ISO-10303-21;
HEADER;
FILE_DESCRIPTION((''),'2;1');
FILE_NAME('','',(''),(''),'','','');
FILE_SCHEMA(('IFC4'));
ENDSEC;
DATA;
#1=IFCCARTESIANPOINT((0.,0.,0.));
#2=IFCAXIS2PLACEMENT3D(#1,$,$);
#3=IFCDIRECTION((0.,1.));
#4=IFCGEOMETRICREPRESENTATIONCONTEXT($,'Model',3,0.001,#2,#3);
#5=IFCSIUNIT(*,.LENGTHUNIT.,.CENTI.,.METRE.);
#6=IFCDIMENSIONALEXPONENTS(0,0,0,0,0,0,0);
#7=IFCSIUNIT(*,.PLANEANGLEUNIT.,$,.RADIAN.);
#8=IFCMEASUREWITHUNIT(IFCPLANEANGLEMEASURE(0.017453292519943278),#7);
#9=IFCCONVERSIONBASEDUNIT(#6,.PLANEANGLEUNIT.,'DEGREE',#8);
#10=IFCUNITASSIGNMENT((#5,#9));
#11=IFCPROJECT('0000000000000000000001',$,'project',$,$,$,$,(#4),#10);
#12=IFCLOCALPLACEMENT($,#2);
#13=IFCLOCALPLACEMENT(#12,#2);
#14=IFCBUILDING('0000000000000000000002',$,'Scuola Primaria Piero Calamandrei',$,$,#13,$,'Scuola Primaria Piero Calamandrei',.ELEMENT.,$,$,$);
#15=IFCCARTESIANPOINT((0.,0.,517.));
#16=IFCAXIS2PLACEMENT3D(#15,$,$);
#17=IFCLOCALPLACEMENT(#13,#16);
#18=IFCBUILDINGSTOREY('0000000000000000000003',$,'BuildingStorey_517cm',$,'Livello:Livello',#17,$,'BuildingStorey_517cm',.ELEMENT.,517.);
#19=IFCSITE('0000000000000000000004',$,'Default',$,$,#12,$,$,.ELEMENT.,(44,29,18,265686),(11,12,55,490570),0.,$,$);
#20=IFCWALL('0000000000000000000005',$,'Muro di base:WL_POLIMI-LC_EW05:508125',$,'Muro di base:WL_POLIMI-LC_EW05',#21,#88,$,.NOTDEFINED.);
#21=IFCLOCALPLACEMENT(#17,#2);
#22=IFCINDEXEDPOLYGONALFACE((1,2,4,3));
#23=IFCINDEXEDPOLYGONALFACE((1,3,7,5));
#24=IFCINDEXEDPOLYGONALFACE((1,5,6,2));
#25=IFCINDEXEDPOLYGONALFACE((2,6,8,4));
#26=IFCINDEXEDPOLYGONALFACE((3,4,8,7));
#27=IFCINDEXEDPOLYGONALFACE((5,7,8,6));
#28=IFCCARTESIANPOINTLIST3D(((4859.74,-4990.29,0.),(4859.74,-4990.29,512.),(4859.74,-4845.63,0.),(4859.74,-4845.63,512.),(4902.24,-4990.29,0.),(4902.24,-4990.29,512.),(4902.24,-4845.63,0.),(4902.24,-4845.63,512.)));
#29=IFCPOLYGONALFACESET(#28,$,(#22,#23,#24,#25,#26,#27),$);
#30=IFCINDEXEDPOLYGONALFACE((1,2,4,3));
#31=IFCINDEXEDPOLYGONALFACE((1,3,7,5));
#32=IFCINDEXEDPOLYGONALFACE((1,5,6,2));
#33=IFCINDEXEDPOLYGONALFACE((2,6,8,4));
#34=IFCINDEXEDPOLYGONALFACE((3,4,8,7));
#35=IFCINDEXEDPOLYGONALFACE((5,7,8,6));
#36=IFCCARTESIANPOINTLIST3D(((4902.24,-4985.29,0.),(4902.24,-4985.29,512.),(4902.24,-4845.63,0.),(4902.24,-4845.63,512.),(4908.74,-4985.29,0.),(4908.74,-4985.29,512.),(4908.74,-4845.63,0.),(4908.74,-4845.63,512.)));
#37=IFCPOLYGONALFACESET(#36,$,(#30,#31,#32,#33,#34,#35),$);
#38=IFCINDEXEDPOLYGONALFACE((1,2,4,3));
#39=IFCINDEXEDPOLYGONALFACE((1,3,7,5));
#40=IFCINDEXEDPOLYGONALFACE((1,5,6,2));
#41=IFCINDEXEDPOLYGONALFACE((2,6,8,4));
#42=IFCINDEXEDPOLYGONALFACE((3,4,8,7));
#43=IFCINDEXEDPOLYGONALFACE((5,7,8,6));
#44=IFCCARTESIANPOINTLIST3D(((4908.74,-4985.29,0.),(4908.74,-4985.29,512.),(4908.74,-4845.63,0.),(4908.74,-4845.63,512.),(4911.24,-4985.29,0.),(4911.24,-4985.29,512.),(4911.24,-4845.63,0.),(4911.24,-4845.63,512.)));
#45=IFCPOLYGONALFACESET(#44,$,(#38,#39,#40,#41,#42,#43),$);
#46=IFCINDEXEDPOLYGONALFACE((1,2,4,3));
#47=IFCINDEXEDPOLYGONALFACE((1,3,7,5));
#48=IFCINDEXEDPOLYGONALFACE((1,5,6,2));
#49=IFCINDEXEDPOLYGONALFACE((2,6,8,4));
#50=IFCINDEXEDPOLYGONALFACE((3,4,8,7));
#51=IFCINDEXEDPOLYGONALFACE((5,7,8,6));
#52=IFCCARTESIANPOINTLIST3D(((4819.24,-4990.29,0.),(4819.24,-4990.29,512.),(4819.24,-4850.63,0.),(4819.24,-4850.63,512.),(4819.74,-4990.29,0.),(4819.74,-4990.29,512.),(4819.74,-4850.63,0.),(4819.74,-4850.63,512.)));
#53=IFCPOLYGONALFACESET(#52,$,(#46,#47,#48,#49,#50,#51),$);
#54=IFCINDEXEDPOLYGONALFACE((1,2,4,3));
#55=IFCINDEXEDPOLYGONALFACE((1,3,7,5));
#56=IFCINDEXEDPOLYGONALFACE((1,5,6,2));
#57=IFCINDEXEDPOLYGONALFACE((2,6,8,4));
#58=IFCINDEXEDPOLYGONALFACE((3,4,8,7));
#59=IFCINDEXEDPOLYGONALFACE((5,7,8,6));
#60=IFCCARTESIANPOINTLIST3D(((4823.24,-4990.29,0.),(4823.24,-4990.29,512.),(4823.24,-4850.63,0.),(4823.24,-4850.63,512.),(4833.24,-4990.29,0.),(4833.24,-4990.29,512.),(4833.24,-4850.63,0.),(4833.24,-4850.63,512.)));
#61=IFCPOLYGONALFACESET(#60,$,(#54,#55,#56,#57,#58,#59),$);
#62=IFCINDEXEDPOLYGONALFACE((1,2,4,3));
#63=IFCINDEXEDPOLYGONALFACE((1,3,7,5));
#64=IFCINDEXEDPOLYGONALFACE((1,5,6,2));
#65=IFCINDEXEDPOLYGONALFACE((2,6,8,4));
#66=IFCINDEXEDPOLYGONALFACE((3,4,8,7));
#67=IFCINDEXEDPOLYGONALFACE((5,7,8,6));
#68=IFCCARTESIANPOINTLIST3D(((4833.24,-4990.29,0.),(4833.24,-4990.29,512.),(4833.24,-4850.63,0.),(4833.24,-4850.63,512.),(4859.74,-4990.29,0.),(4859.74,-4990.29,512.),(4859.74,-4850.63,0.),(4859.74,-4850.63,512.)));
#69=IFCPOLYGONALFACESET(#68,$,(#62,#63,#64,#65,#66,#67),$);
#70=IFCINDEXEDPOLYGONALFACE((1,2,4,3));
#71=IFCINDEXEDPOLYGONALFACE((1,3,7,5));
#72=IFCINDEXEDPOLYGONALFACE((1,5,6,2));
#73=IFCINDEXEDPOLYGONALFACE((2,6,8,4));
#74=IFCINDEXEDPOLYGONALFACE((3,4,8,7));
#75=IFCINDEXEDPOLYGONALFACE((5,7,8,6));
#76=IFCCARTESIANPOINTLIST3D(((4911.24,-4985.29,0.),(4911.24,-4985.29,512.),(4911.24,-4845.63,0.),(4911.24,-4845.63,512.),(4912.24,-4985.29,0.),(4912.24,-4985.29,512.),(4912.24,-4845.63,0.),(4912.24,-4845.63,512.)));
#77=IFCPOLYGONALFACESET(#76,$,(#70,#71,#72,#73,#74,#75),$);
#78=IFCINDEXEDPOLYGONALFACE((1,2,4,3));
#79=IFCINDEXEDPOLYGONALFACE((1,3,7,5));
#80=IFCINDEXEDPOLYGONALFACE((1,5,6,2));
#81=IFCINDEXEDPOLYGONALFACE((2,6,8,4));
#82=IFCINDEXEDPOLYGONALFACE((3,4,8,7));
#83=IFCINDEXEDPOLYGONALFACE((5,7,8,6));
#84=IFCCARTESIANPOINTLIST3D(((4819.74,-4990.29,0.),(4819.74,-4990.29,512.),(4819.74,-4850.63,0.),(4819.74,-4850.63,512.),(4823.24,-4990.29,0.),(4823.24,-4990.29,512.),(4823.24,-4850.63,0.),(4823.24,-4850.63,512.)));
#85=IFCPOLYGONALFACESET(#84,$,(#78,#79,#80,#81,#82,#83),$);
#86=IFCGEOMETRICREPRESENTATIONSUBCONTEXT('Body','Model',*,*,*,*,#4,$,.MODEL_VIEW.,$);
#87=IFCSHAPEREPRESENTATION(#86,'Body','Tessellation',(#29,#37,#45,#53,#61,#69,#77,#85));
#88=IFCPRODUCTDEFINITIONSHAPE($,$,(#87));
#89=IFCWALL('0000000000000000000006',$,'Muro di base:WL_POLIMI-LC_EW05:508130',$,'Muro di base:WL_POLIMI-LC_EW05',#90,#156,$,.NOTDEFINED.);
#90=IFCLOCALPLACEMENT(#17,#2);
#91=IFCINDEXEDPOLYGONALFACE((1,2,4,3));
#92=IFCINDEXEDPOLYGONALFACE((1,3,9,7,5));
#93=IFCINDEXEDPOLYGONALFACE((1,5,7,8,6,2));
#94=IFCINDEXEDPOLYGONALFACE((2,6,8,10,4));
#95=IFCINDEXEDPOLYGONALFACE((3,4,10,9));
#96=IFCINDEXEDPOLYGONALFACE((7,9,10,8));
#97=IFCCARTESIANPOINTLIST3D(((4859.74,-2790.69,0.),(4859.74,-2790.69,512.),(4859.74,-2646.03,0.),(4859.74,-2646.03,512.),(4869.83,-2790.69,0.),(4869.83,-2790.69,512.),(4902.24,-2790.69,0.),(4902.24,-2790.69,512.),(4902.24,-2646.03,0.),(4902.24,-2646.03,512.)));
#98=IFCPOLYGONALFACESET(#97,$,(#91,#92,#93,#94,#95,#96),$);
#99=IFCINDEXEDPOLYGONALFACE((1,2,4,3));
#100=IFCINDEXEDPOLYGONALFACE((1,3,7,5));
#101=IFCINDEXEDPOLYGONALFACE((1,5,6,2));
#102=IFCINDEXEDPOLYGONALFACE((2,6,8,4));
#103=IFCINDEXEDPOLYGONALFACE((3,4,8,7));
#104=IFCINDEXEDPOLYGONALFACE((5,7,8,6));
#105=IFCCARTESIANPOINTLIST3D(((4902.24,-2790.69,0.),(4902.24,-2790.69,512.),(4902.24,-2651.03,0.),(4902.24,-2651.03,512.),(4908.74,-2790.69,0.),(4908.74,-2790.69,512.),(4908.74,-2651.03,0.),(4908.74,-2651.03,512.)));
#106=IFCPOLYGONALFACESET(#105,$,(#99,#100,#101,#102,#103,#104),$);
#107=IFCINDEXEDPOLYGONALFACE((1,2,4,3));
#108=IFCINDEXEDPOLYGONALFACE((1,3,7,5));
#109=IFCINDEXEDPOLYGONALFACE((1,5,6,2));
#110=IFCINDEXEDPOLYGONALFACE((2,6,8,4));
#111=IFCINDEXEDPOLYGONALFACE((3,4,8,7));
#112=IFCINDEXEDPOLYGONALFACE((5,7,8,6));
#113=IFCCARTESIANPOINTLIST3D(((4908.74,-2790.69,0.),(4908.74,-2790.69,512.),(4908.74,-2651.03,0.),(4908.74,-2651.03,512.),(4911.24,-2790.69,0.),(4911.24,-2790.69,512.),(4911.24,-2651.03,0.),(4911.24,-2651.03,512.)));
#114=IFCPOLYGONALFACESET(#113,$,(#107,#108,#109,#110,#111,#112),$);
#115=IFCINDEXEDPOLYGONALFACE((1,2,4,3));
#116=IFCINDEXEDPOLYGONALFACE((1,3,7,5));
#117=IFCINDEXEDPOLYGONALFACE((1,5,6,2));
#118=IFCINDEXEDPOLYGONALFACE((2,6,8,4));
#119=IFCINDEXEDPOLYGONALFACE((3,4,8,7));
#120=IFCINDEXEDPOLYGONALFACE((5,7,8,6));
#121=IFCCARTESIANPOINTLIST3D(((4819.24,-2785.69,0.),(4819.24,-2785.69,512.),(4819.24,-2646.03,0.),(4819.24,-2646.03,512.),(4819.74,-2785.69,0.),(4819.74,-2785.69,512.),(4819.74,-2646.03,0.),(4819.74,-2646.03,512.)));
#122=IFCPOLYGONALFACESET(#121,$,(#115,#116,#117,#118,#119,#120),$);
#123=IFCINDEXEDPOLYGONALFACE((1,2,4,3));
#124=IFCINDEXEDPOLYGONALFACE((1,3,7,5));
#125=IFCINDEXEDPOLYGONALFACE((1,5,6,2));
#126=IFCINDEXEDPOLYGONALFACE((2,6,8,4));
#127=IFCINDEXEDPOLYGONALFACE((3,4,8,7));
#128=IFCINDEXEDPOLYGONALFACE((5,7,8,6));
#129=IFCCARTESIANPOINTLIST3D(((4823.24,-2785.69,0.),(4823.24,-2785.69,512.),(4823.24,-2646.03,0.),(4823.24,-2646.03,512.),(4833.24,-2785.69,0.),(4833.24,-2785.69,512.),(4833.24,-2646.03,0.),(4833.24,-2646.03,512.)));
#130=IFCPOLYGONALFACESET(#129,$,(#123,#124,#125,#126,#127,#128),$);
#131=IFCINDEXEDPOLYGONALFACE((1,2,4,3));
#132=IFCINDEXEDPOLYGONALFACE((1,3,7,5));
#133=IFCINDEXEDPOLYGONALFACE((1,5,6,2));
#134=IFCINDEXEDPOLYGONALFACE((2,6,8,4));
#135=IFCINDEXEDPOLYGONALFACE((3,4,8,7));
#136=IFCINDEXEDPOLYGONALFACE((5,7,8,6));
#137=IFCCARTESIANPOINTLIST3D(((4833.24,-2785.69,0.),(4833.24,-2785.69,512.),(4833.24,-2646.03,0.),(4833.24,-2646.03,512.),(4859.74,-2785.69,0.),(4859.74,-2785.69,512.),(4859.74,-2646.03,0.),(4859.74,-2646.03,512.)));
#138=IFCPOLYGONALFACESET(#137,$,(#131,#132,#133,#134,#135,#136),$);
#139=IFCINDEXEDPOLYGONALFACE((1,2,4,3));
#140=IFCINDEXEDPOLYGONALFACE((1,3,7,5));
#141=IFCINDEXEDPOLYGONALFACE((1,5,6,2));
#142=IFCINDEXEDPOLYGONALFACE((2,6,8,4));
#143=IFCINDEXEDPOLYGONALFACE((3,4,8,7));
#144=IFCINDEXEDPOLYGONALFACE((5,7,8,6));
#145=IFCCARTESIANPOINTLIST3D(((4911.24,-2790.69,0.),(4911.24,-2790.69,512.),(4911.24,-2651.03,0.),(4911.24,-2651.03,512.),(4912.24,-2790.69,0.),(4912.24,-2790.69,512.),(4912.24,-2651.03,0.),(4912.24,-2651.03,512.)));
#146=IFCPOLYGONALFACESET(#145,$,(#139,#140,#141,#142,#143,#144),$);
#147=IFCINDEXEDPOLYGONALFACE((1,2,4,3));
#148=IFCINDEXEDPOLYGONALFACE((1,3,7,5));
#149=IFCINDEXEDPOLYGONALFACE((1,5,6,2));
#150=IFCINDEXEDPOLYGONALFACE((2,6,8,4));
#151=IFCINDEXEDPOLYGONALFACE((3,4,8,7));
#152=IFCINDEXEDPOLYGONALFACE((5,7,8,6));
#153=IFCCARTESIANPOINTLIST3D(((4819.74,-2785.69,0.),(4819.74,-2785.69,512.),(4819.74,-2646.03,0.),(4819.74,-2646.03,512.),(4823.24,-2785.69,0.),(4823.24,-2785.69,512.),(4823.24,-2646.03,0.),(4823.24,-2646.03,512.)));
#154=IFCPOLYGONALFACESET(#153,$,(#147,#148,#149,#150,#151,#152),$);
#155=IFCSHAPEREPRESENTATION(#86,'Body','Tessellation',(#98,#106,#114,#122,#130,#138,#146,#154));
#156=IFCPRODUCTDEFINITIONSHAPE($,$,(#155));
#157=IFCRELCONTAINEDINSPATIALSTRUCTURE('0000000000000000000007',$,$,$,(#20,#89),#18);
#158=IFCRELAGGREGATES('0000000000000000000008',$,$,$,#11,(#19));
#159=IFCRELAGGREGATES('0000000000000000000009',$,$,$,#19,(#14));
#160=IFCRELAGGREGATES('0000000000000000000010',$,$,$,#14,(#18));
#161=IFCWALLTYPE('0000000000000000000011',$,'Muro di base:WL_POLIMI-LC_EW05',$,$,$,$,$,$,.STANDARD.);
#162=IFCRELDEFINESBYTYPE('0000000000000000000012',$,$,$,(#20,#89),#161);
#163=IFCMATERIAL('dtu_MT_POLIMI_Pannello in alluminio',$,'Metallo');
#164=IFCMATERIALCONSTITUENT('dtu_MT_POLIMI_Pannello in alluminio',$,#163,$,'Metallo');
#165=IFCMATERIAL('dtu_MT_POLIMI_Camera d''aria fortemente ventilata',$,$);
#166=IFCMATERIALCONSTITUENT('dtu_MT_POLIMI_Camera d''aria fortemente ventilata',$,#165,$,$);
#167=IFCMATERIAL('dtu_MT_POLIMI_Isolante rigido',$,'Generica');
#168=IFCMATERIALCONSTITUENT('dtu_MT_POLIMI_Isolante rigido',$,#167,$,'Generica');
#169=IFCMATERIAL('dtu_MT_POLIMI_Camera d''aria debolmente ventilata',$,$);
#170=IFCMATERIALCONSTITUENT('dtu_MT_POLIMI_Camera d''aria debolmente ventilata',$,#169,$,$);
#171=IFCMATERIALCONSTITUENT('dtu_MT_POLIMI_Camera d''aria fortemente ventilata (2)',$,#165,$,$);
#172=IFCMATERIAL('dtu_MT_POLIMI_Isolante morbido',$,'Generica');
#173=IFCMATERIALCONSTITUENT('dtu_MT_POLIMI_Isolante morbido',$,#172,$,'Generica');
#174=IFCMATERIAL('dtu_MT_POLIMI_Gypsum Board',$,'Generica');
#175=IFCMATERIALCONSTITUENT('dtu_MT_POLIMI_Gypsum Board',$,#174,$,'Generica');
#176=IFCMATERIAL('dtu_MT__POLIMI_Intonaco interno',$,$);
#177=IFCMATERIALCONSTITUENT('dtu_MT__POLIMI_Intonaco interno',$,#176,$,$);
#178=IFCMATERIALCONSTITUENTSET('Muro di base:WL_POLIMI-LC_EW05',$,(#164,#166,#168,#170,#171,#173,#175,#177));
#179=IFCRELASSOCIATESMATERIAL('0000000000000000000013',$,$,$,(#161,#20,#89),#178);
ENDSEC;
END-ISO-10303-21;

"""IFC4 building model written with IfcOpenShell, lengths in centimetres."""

from ifc_helpers import new_model, entity, si_unit, converted_unit, direction, frame, origin, place, context, subcontext, project, spatial, indexed_curve, outline, extrude, material, constituent, constituent_set, type_object, element, save


model = new_model("IFC4")

# Units and contexts
model_context = context("Model", 3, precision=0.001, world=origin(), true_north=direction((0.0, 1.0)))
body_context = subcontext(model_context, "Body", "Model", "MODEL_VIEW")
ifc_project = project(units=[si_unit("LENGTHUNIT", "METRE", prefix="CENTI"), converted_unit("PLANEANGLEUNIT", "DEGREE", entity("IfcPlaneAngleMeasure", 0.017453292519943278), si_unit("PLANEANGLEUNIT", "RADIAN"), dimensions=[0, 0, 0, 0, 0, 0, 0])], contexts=[model_context])

# Site, building, storey
site_placement = place(None, origin())
site = spatial("IfcSite", under=ifc_project, at=site_placement, Name="Default", CompositionType="ELEMENT", RefLatitude=(44, 29, 18, 265686), RefLongitude=(11, 12, 55, 490570), RefElevation=0.0)
building_placement = place(site_placement, origin())
building = spatial("IfcBuilding", under=site, at=building_placement, Name="Scuola Primaria Piero Calamandrei", LongName="Scuola Primaria Piero Calamandrei", CompositionType="ELEMENT")
storey_placement = place(building_placement, frame((0.0, 0.0, 517.0)))
storey = spatial("IfcBuildingStorey", under=building, at=storey_placement, Name="BuildingStorey_517cm", ObjectType="Livello:Livello", LongName="BuildingStorey_517cm", CompositionType="ELEMENT", Elevation=517.0)

# Shared definitions
ifc_material_1 = material(Name="dtu_MT_POLIMI_Pannello in alluminio", Category="Metallo")
ifc_constituent_1 = constituent(ifc_material_1, Name="dtu_MT_POLIMI_Pannello in alluminio", Category="Metallo")
ifc_material_2 = material(Name="dtu_MT_POLIMI_Camera d'aria fortemente ventilata")
ifc_constituent_2 = constituent(ifc_material_2, Name="dtu_MT_POLIMI_Camera d'aria fortemente ventilata")
ifc_material_3 = material(Name="dtu_MT_POLIMI_Isolante rigido", Category="Generica")
ifc_constituent_3 = constituent(ifc_material_3, Name="dtu_MT_POLIMI_Isolante rigido", Category="Generica")
ifc_material_4 = material(Name="dtu_MT_POLIMI_Camera d'aria debolmente ventilata")
ifc_constituent_4 = constituent(ifc_material_4, Name="dtu_MT_POLIMI_Camera d'aria debolmente ventilata")
ifc_constituent_5 = constituent(ifc_material_2, Name="dtu_MT_POLIMI_Camera d'aria fortemente ventilata (2)")
ifc_material_5 = material(Name="dtu_MT_POLIMI_Isolante morbido", Category="Generica")
ifc_constituent_6 = constituent(ifc_material_5, Name="dtu_MT_POLIMI_Isolante morbido", Category="Generica")
ifc_material_6 = material(Name="dtu_MT_POLIMI_Gypsum Board", Category="Generica")
ifc_constituent_7 = constituent(ifc_material_6, Name="dtu_MT_POLIMI_Gypsum Board", Category="Generica")
ifc_material_7 = material(Name="dtu_MT__POLIMI_Intonaco interno")
ifc_constituent_8 = constituent(ifc_material_7, Name="dtu_MT__POLIMI_Intonaco interno")
ifc_constituent_set_1 = constituent_set(constituents=[ifc_constituent_1, ifc_constituent_2, ifc_constituent_3, ifc_constituent_4, ifc_constituent_5, ifc_constituent_6, ifc_constituent_7, ifc_constituent_8], Name="Muro di base:WL_POLIMI-LC_EW05")
wall_type_1 = type_object("IfcWallType", Name="Muro di base:WL_POLIMI-LC_EW05", PredefinedType="STANDARD", material=ifc_constituent_set_1)

# Walls
wall_1_placement = place(storey_placement, frame((4865.74, -4990.29, 0.0), z_axis=(0.0, 0.0, 1.0), x_axis=(0.0, 1.0, 0.0)))
element("IfcWall", 1, at=wall_1_placement, inside=storey, type_object=wall_type_1, material=ifc_constituent_set_1, Name="Muro di base:WL_POLIMI-LC_EW05:508125", ObjectType="Muro di base:WL_POLIMI-LC_EW05", PredefinedType="NOTDEFINED", context=body_context, shape_type="SweptSolid", body=[
    extrude(outline(indexed_curve([(-72.33, -21.25), (72.33, -21.25), (72.33, 21.25), (-72.33, 21.25), (-72.33, -21.25)], self_intersect=False)), frame((72.33, -15.25, 0.0)), (0.0, 0.0, 1.0), 512.0),
    extrude(outline(indexed_curve([(-69.83, -3.25), (69.83, -3.25), (69.83, 3.25), (-69.83, 3.25), (-69.83, -3.25)], self_intersect=False)), frame((74.83, -39.75, 0.0)), (0.0, 0.0, 1.0), 512.0),
    extrude(outline(indexed_curve([(-69.83, -1.25), (69.83, -1.25), (69.83, 1.25), (-69.83, 1.25), (-69.83, -1.25)], self_intersect=False)), frame((74.83, -44.25, 0.0)), (0.0, 0.0, 1.0), 512.0),
    extrude(outline(indexed_curve([(-69.83, -0.25), (69.83, -0.25), (69.83, 0.25), (-69.83, 0.25), (-69.83, -0.25)], self_intersect=False)), frame((69.83, 46.25, 0.0), z_axis=(0.0, 0.0, 1.0), x_axis=(-1.0, 0.0, 0.0)), (0.0, 0.0, 1.0), 512.0),
    extrude(outline(indexed_curve([(-69.83, -5.0), (69.83, -5.0), (69.83, 5.0), (-69.83, 5.0), (-69.83, -5.0)], self_intersect=False)), frame((69.83, 37.5, 0.0)), (0.0, 0.0, 1.0), 512.0),
    extrude(outline(indexed_curve([(-69.83, -13.25), (69.83, -13.25), (69.83, 13.25), (-69.83, 13.25), (-69.83, -13.25)], self_intersect=False)), frame((69.83, 19.25, 0.0)), (0.0, 0.0, 1.0), 512.0),
    extrude(outline(indexed_curve([(-69.83, -0.5), (69.83, -0.5), (69.83, 0.5), (-69.83, 0.5), (-69.83, -0.5)], self_intersect=False)), frame((74.83, -46.0, 0.0)), (0.0, 0.0, 1.0), 512.0),
    extrude(outline(indexed_curve([(-69.83, -1.75), (69.83, -1.75), (69.83, 1.75), (-69.83, 1.75), (-69.83, -1.75)], self_intersect=False)), frame((69.83, 44.25, 0.0)), (0.0, 0.0, 1.0), 512.0),
])
wall_2_placement = place(storey_placement, frame((4865.74, -2790.69, 0.0), z_axis=(0.0, 0.0, 1.0), x_axis=(0.0, 1.0, 0.0)))
element("IfcWall", 2, at=wall_2_placement, inside=storey, type_object=wall_type_1, material=ifc_constituent_set_1, Name="Muro di base:WL_POLIMI-LC_EW05:508130", ObjectType="Muro di base:WL_POLIMI-LC_EW05", PredefinedType="NOTDEFINED", context=body_context, shape_type="SweptSolid", body=[
    extrude(outline(indexed_curve([(-57.86, -23.48), (86.79, -23.48), (86.79, 19.02), (-57.86, 19.02), (-57.86, 8.93), (-57.86, -23.48)], self_intersect=False)), frame((57.86, -13.02, 0.0)), (0.0, 0.0, 1.0), 512.0),
    extrude(outline(indexed_curve([(-69.83, -3.25), (69.83, -3.25), (69.83, 3.25), (-69.83, 3.25), (-69.83, -3.25)], self_intersect=False)), frame((69.83, -39.75, 0.0)), (0.0, 0.0, 1.0), 512.0),
    extrude(outline(indexed_curve([(-69.83, -1.25), (69.83, -1.25), (69.83, 1.25), (-69.83, 1.25), (-69.83, -1.25)], self_intersect=False)), frame((69.83, -44.25, 0.0)), (0.0, 0.0, 1.0), 512.0),
    extrude(outline(indexed_curve([(-0.25, -69.83), (0.25, -69.83), (0.25, 69.83), (-0.25, 69.83), (-0.25, -69.83)], self_intersect=False)), frame((74.83, 46.25, 0.0), z_axis=(0.0, 0.0, 1.0), x_axis=(0.0, -1.0, 0.0)), (0.0, 0.0, 1.0), 512.0),
    extrude(outline(indexed_curve([(-69.83, -5.0), (69.83, -5.0), (69.83, 5.0), (-69.83, 5.0), (-69.83, -5.0)], self_intersect=False)), frame((74.83, 37.5, 0.0)), (0.0, 0.0, 1.0), 512.0),
    extrude(outline(indexed_curve([(-69.83, -13.25), (69.83, -13.25), (69.83, 13.25), (-69.83, 13.25), (-69.83, -13.25)], self_intersect=False)), frame((74.83, 19.25, 0.0)), (0.0, 0.0, 1.0), 512.0),
    extrude(outline(indexed_curve([(-0.5, -69.83), (0.5, -69.83), (0.5, 69.83), (-0.5, 69.83), (-0.5, -69.83)], self_intersect=False)), frame((69.83, -46.0, 0.0), z_axis=(0.0, 0.0, 1.0), x_axis=(0.0, 1.0, 0.0)), (0.0, 0.0, 1.0), 512.0),
    extrude(outline(indexed_curve([(-69.83, -1.75), (69.83, -1.75), (69.83, 1.75), (-69.83, 1.75), (-69.83, -1.75)], self_intersect=False)), frame((74.83, 44.25, 0.0)), (0.0, 0.0, 1.0), 512.0),
])

save(model, "model.ifc")
